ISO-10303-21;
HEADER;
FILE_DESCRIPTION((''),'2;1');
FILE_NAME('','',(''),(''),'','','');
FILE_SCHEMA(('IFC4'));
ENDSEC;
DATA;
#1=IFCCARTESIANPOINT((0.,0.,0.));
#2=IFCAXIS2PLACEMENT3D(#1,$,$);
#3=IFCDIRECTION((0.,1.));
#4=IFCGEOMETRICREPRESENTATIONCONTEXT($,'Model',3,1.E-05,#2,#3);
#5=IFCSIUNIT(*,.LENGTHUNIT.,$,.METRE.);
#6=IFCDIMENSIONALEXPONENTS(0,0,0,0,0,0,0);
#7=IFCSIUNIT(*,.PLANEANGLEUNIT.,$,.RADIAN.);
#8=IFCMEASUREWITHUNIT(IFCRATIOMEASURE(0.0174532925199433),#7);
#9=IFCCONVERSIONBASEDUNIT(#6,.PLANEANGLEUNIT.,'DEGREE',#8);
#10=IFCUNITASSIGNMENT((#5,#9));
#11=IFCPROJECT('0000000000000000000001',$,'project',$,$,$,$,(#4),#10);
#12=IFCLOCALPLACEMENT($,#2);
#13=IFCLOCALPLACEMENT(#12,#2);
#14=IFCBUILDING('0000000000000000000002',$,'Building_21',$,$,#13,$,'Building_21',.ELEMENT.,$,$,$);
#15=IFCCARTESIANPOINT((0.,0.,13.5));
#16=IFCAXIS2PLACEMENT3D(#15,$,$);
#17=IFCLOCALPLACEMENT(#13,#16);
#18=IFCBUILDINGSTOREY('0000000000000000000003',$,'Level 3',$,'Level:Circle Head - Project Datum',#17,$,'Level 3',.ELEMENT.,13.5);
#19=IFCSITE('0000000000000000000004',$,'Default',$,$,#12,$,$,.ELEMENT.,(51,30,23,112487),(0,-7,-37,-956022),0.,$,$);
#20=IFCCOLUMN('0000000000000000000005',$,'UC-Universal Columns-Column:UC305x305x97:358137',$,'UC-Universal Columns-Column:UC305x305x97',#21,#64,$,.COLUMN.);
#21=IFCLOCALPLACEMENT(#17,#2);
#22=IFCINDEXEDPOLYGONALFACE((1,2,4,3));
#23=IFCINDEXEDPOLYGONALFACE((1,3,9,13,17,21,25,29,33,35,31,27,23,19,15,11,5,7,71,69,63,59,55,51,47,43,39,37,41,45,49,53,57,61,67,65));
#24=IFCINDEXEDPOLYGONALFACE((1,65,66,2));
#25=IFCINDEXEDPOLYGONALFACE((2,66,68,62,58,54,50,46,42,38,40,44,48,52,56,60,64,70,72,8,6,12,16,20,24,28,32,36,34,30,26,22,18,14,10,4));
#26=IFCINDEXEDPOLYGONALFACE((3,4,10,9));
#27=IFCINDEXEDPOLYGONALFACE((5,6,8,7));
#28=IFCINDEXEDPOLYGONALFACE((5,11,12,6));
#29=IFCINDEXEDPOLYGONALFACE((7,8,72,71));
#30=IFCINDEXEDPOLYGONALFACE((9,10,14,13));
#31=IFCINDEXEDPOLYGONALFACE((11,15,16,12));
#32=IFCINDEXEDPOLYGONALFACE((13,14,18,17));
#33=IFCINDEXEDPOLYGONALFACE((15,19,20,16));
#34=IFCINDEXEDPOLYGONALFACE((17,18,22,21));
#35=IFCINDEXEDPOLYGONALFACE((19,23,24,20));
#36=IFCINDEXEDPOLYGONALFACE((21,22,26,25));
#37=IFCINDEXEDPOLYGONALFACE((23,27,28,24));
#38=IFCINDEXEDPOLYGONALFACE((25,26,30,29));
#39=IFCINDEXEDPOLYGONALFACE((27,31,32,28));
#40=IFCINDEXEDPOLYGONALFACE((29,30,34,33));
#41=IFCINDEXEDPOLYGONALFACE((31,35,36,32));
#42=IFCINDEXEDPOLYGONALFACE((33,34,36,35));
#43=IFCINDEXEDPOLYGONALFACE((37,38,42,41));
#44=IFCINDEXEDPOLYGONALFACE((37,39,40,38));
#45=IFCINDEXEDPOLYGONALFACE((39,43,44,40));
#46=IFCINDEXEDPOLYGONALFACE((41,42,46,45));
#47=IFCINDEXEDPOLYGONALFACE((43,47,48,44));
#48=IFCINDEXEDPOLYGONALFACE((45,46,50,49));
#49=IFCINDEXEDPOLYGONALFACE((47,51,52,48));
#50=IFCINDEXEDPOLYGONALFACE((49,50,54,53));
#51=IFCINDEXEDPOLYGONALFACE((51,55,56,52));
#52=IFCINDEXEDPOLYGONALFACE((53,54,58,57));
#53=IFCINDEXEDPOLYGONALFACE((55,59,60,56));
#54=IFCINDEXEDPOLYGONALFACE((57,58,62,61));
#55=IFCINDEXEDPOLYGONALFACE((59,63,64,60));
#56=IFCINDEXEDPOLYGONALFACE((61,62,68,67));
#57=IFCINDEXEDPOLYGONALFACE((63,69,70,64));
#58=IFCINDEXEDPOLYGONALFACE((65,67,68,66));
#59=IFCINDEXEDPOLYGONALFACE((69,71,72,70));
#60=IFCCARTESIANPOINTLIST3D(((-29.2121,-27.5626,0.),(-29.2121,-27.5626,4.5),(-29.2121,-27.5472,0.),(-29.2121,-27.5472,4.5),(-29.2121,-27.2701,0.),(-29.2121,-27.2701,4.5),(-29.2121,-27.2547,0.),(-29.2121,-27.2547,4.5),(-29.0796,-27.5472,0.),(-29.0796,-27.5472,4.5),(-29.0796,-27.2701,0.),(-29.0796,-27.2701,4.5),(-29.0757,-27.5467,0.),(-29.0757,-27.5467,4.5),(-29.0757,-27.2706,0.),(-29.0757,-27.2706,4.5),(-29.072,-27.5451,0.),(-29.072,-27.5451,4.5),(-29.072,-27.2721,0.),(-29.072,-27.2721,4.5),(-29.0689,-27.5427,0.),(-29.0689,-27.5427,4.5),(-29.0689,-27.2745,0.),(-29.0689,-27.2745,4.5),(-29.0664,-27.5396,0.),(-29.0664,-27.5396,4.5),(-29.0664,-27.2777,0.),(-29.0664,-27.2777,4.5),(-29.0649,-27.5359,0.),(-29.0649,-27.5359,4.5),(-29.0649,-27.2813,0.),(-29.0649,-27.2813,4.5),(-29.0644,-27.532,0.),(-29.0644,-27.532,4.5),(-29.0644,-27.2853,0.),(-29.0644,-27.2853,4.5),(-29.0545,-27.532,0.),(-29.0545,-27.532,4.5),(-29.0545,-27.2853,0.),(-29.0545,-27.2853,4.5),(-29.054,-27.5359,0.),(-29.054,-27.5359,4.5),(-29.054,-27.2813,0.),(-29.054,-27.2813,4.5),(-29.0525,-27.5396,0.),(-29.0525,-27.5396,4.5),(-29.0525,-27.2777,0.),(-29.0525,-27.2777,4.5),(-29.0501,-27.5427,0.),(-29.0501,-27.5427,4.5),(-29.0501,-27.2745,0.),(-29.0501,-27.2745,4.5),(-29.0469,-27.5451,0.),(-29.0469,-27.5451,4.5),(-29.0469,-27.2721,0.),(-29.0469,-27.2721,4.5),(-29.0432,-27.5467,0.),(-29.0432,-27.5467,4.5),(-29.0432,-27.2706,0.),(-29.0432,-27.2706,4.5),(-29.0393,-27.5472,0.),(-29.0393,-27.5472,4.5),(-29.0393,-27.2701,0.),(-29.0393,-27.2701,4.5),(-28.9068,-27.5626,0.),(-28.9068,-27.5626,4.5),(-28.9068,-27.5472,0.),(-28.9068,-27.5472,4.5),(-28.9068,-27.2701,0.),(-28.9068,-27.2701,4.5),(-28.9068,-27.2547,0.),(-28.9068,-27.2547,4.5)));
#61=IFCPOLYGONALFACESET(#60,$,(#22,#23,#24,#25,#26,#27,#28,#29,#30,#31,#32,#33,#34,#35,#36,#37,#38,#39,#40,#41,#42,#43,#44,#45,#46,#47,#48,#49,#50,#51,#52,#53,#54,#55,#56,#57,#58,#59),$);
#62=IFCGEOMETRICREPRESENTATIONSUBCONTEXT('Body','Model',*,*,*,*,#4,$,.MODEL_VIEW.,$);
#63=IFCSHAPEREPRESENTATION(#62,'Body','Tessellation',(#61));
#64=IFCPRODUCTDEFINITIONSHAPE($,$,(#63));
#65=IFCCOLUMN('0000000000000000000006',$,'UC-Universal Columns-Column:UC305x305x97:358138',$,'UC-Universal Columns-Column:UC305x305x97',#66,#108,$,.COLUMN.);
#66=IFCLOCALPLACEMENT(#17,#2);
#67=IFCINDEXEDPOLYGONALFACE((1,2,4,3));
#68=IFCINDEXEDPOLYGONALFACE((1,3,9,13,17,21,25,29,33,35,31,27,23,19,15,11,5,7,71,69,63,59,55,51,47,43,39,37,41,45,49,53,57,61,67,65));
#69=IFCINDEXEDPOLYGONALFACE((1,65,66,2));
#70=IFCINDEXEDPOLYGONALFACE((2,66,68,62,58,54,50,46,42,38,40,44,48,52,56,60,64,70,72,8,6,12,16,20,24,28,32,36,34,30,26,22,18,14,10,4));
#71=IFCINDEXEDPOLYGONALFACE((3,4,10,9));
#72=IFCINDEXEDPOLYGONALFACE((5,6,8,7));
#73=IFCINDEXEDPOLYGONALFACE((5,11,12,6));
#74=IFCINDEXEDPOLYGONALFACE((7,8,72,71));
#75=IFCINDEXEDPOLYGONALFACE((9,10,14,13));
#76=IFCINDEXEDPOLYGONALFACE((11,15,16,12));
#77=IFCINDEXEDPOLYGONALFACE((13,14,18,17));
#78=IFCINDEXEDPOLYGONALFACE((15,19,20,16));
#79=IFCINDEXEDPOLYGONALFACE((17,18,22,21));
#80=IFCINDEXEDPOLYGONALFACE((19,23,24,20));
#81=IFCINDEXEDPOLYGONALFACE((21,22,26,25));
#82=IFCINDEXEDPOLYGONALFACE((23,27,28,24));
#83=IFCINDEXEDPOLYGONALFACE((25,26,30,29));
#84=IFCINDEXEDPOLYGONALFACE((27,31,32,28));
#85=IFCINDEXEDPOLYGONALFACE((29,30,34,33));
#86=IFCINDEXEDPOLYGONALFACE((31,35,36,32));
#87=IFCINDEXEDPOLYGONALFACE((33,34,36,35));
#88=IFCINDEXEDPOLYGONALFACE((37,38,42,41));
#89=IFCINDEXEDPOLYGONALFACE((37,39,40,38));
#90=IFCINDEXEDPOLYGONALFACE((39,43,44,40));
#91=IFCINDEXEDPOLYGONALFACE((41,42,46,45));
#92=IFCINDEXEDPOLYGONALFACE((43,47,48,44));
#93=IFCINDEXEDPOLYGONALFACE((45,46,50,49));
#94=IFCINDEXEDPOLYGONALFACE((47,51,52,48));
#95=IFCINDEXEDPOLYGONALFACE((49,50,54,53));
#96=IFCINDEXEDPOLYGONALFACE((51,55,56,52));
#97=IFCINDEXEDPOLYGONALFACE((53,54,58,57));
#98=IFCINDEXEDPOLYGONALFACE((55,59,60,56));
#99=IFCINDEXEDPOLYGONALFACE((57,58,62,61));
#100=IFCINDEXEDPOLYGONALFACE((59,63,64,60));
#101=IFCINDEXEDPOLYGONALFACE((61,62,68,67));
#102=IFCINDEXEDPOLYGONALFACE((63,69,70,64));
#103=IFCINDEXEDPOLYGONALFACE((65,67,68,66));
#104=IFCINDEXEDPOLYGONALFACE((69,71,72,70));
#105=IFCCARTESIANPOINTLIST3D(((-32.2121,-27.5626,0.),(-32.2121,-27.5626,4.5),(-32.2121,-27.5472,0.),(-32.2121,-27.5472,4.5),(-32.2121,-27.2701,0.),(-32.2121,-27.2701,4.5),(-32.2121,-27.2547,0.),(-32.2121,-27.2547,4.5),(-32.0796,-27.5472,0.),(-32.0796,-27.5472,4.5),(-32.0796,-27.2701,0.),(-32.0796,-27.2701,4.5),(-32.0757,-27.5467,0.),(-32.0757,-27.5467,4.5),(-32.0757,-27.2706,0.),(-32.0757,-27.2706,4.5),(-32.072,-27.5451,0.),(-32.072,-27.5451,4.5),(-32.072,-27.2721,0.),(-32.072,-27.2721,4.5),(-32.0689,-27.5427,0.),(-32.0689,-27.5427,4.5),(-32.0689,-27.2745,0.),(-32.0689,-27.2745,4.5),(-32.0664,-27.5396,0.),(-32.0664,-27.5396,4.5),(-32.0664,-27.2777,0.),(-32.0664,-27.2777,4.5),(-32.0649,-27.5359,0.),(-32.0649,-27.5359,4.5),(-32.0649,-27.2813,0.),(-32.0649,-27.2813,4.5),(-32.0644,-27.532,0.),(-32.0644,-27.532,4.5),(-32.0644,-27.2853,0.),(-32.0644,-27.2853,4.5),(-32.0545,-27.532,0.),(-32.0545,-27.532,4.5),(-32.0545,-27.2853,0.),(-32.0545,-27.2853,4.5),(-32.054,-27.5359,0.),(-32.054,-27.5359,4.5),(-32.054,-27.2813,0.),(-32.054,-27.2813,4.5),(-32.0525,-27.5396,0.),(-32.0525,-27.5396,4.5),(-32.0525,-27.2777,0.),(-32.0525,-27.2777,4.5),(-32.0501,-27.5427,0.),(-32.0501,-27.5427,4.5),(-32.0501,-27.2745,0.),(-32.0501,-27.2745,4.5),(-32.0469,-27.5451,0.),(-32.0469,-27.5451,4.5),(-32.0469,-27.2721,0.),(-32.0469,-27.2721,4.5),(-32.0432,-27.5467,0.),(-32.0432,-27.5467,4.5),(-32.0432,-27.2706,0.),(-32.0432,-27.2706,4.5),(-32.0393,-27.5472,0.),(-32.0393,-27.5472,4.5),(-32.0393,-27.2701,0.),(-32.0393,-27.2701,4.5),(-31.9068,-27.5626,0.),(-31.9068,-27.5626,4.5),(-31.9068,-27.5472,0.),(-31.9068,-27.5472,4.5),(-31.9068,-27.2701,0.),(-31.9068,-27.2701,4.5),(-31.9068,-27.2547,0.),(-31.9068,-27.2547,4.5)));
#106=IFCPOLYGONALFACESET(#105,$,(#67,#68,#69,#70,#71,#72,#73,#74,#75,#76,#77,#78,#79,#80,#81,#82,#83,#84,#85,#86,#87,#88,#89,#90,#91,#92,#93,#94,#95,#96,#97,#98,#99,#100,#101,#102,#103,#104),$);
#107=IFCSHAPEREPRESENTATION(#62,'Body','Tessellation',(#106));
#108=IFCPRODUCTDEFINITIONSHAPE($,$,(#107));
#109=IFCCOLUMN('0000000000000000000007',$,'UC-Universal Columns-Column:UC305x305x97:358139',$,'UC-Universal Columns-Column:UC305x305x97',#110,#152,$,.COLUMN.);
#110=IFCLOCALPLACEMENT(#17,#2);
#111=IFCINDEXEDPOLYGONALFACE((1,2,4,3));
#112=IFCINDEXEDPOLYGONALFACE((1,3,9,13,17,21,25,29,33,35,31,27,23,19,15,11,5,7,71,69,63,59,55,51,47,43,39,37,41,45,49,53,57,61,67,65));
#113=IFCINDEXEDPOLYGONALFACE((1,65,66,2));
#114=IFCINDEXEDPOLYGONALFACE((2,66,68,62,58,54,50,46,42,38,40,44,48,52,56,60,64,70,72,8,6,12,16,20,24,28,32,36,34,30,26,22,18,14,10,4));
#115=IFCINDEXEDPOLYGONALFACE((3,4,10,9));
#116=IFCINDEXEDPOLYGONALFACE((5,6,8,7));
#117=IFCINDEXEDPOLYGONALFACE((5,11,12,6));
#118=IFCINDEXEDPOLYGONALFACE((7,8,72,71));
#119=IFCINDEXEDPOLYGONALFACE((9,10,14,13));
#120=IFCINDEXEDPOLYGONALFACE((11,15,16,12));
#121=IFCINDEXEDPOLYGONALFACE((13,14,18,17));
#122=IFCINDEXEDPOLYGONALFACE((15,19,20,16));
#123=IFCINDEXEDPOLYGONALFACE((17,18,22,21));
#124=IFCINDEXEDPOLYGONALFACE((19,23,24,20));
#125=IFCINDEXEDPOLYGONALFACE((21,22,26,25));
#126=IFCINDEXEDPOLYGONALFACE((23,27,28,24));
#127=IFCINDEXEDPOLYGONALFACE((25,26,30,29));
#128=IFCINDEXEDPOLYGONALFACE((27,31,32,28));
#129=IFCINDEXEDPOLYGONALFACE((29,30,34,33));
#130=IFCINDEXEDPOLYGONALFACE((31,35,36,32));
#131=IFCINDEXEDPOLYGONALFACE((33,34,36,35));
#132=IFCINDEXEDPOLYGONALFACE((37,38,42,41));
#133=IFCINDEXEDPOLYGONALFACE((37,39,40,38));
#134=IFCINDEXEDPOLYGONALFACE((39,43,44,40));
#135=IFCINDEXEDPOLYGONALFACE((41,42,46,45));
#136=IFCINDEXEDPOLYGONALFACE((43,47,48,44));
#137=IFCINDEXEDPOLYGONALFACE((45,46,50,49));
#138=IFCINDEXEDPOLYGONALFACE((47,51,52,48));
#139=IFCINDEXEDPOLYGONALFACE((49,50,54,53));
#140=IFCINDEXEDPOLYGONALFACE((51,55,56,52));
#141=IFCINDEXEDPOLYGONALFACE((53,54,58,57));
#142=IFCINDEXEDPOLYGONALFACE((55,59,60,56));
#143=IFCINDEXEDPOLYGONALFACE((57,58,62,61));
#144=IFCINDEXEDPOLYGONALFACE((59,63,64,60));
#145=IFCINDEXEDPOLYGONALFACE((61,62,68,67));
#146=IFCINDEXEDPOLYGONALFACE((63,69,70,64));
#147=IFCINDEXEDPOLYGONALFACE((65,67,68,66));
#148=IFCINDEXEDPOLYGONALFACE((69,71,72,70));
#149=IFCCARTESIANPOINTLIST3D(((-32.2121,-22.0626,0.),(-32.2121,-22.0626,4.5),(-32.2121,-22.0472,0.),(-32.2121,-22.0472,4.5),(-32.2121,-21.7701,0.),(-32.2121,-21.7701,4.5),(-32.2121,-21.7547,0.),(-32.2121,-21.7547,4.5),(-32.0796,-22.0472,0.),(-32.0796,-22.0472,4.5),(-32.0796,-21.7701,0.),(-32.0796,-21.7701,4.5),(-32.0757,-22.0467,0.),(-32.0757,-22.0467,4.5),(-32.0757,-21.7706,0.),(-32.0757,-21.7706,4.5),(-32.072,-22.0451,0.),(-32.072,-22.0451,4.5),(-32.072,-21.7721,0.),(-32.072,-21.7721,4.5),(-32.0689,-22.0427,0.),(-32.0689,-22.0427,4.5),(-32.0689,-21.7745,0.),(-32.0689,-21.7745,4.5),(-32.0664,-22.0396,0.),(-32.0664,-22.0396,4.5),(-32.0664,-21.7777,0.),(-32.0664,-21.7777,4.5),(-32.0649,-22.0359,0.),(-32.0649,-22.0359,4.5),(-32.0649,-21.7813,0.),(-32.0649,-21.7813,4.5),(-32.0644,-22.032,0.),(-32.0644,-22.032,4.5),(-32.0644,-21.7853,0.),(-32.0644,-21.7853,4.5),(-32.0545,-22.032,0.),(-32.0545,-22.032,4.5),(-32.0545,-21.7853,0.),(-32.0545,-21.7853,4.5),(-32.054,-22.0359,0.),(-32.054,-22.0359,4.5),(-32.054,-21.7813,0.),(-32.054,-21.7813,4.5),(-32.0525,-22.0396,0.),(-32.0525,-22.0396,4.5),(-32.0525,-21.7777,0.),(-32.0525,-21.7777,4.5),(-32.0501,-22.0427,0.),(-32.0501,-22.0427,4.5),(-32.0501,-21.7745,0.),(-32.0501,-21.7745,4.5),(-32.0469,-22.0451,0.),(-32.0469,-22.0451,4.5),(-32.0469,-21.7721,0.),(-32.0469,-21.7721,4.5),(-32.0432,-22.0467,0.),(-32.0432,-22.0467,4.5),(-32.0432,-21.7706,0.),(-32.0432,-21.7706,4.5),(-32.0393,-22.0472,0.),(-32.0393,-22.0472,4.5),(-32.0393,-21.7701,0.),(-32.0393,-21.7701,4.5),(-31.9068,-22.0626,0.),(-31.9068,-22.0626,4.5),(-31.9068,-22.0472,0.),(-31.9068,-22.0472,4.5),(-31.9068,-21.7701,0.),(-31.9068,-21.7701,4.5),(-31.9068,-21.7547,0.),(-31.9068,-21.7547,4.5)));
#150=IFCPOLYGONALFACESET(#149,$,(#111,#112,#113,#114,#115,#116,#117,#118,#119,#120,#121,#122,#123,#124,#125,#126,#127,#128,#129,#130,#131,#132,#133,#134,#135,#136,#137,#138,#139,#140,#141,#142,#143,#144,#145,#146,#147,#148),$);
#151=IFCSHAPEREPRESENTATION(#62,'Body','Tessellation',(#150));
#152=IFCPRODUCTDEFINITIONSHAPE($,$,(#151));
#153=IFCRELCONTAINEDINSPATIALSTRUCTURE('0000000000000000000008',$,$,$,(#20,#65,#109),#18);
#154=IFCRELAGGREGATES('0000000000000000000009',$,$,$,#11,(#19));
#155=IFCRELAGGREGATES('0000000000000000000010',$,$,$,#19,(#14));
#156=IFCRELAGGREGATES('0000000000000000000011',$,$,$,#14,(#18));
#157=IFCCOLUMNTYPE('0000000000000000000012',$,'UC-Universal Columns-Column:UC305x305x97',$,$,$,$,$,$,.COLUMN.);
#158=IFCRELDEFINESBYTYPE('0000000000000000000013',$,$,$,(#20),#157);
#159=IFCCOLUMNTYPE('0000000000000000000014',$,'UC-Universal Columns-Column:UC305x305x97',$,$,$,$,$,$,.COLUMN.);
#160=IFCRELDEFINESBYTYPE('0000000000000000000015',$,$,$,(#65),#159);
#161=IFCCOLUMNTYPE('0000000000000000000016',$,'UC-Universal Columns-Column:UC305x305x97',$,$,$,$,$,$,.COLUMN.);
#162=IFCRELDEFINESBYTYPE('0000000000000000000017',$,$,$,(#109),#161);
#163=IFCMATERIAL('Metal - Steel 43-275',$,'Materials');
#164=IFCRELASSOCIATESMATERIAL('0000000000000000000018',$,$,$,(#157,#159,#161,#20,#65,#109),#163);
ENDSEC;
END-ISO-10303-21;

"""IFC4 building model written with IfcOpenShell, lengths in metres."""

from ifc_helpers import new_model, entity, si_unit, converted_unit, direction, frame, frame_2d, origin, place, context, subcontext, project, spatial, polyline, circle_curve, parameter, trimmed, segment, composite_curve, i_section, outline, extrude, source, transform, mapped, material, material_profile, profile_set, profile_usage, type_object, type_shapes, element, save


model = new_model("IFC4")

# Units and contexts
model_context = context("Model", 3, precision=1e-05, world=origin(), true_north=direction((0.0, 1.0)))
body_context = subcontext(model_context, "Body", "Model", "MODEL_VIEW")
ifc_project = project(units=[si_unit("LENGTHUNIT", "METRE"), converted_unit("PLANEANGLEUNIT", "DEGREE", entity("IfcRatioMeasure", 0.0174532925199433), si_unit("PLANEANGLEUNIT", "RADIAN"), dimensions=[0, 0, 0, 0, 0, 0, 0])], contexts=[model_context])

# Site, building, storey
site_placement = place(None, origin())
site = spatial("IfcSite", under=ifc_project, at=site_placement, Name="Default", CompositionType="ELEMENT", RefLatitude=(51, 30, 23, 112487), RefLongitude=(0, -7, -37, -956022), RefElevation=0.0)
building_placement = place(site_placement, origin())
building = spatial("IfcBuilding", under=site, at=building_placement, Name="Building_21", LongName="Building_21", CompositionType="ELEMENT")
storey_placement = place(building_placement, frame((0.0, 0.0, 13.5)))
storey = spatial("IfcBuildingStorey", under=building, at=storey_placement, Name="Level 3", ObjectType="Level:Circle Head - Project Datum", LongName="Level 3", CompositionType="ELEMENT", Elevation=13.5)

# Columns
ifc_material_1 = material(Name="Metal - Steel 43-275", Category="Materials")
ifc_material_profile_1 = material_profile(ifc_material_1, outline(composite_curve([segment(polyline([(-0.1527, 0.154, 0.0), (0.1527, 0.154, 0.0)]), True, "CONTINUOUS"), segment(polyline([(0.1527, 0.154, 0.0), (0.1527, 0.1386, 0.0)]), True, "CONTINUOUS"), segment(polyline([(0.1527, 0.1386, 0.0), (0.0201, 0.1386, 0.0)]), True, "CONTINUOUS"), segment(trimmed(circle_curve(frame((0.0201, 0.1234, 0.0)), 0.0152), [parameter(90.0)], [parameter(180.0)], True, "PARAMETER"), True, "CONTINUOUS"), segment(polyline([(0.0049, 0.1234, 0.0), (0.0049, -0.1234, 0.0)]), True, "CONTINUOUS"), segment(trimmed(circle_curve(frame((0.0201, -0.1234, 0.0)), 0.0152), [parameter(180.0)], [parameter(270.0)], True, "PARAMETER"), True, "CONTINUOUS"), segment(polyline([(0.0201, -0.1386, 0.0), (0.1527, -0.1386, 0.0)]), True, "CONTINUOUS"), segment(polyline([(0.1527, -0.1386, 0.0), (0.1527, -0.154, 0.0)]), True, "CONTINUOUS"), segment(polyline([(0.1527, -0.154, 0.0), (-0.1527, -0.154, 0.0)]), True, "CONTINUOUS"), segment(polyline([(-0.1527, -0.154, 0.0), (-0.1527, -0.1386, 0.0)]), True, "CONTINUOUS"), segment(polyline([(-0.1527, -0.1386, 0.0), (-0.0201, -0.1386, 0.0)]), True, "CONTINUOUS"), segment(trimmed(circle_curve(frame((-0.0201, -0.1234, 0.0)), 0.0152), [parameter(270.0)], [parameter(0.0)], True, "PARAMETER"), True, "CONTINUOUS"), segment(polyline([(-0.0049, -0.1234, 0.0), (-0.005, 0.1234, 0.0)]), True, "CONTINUOUS"), segment(trimmed(circle_curve(frame((-0.0201, 0.1234, 0.0)), 0.0152), [parameter(0.0)], [parameter(90.0)], True, "PARAMETER"), True, "CONTINUOUS"), segment(polyline([(-0.0201, 0.1386, 0.0), (-0.1527, 0.1386, 0.0)]), True, "CONTINUOUS"), segment(polyline([(-0.1527, 0.1386, 0.0), (-0.1527, 0.154, 0.0)]), True, "CONTINUOUS")], self_intersect=False), kind="CURVE"), Name="UC305x305x97")
ifc_material_profile_2 = material_profile(ifc_material_1, outline(composite_curve([segment(polyline([(0.1527, 0.154, 0.0), (0.1527, 0.1386, 0.0)]), True, "CONTINUOUS"), segment(polyline([(0.1527, 0.1386, 0.0), (0.0049, 0.1386, 0.0)]), True, "CONTINUOUS"), segment(polyline([(0.0049, 0.1386, 0.0), (0.0049, -0.1386, 0.0)]), True, "CONTINUOUS"), segment(polyline([(0.0049, -0.1386, 0.0), (0.1527, -0.1386, 0.0)]), True, "CONTINUOUS"), segment(polyline([(0.1527, -0.1386, 0.0), (0.1527, -0.154, 0.0)]), True, "CONTINUOUS"), segment(polyline([(0.1527, -0.154, 0.0), (-0.1527, -0.154, 0.0)]), True, "CONTINUOUS"), segment(polyline([(-0.1527, -0.154, 0.0), (-0.1527, -0.1386, 0.0)]), True, "CONTINUOUS"), segment(polyline([(-0.1527, -0.1386, 0.0), (-0.005, -0.1386, 0.0)]), True, "CONTINUOUS"), segment(polyline([(-0.005, -0.1386, 0.0), (-0.005, 0.1386, 0.0)]), True, "CONTINUOUS"), segment(polyline([(-0.005, 0.1386, 0.0), (-0.1527, 0.1386, 0.0)]), True, "CONTINUOUS"), segment(polyline([(-0.1527, 0.1386, 0.0), (-0.1527, 0.154, 0.0)]), True, "CONTINUOUS"), segment(polyline([(-0.1527, 0.154, 0.0), (0.1527, 0.154, 0.0)]), True, "CONTINUOUS")], self_intersect=False), kind="CURVE"), Name="UC305x305x97")
ifc_profile_set = profile_set([ifc_material_profile_1, ifc_material_profile_2], Name="UC305x305x97")
ifc_profile_usage_1 = profile_usage(ifc_profile_set)
column_type_1 = type_object("IfcColumnType", Name="UC-Universal Columns-Column:UC305x305x97", PredefinedType="COLUMN", material=ifc_profile_set)
shared_shape_1 = source(origin(), body_context, "Body", "SweptSolid", [
    extrude(i_section(OverallWidth=0.3053, OverallDepth=0.3079, WebThickness=0.0099, FlangeThickness=0.0154, FilletRadius=0.0152, at=frame_2d((0.0, 0.0), x_axis=(0.0, 1.0))), frame((-29.0595, -27.4086, 13.5), z_axis=(0.0, 0.0, 1.0), x_axis=(0.0, -1.0, 0.0)), (0.0, 0.0, 1.0), 4.5),
])
type_shapes(column_type_1, [shared_shape_1])
column_1_placement = place(storey_placement, frame((0.0, 0.0, -13.5)))
element("IfcColumn", 1, at=column_1_placement, inside=storey, type_object=column_type_1, material=ifc_profile_usage_1, Name="UC-Universal Columns-Column:UC305x305x97:358137", ObjectType="UC-Universal Columns-Column:UC305x305x97", PredefinedType="COLUMN", context=body_context, shape_type="MappedRepresentation", body=[
    mapped(shared_shape_1, transform((0.0, 0.0, 0.0), scale=1.0)),
])
ifc_profile_usage_2 = profile_usage(ifc_profile_set)
column_type_2 = type_object("IfcColumnType", Name="UC-Universal Columns-Column:UC305x305x97", PredefinedType="COLUMN", material=ifc_profile_set)
shared_shape_2 = source(origin(), body_context, "Body", "SweptSolid", [
    extrude(i_section(OverallWidth=0.3053, OverallDepth=0.3079, WebThickness=0.0099, FlangeThickness=0.0154, FilletRadius=0.0152, at=frame_2d((0.0, 0.0), x_axis=(0.0, 1.0))), frame((-32.0595, -27.4086, 13.5), z_axis=(0.0, 0.0, 1.0), x_axis=(0.0, -1.0, 0.0)), (0.0, 0.0, 1.0), 4.5),
])
type_shapes(column_type_2, [shared_shape_2])
column_2_placement = place(storey_placement, frame((0.0, 0.0, -13.5)))
element("IfcColumn", 2, at=column_2_placement, inside=storey, type_object=column_type_2, material=ifc_profile_usage_2, Name="UC-Universal Columns-Column:UC305x305x97:358138", ObjectType="UC-Universal Columns-Column:UC305x305x97", PredefinedType="COLUMN", context=body_context, shape_type="MappedRepresentation", body=[
    mapped(shared_shape_2, transform((0.0, 0.0, 0.0), scale=1.0)),
])
ifc_profile_usage_3 = profile_usage(ifc_profile_set)
column_type_3 = type_object("IfcColumnType", Name="UC-Universal Columns-Column:UC305x305x97", PredefinedType="COLUMN", material=ifc_profile_set)
shared_shape_3 = source(origin(), body_context, "Body", "SweptSolid", [
    extrude(i_section(OverallWidth=0.3053, OverallDepth=0.3079, WebThickness=0.0099, FlangeThickness=0.0154, FilletRadius=0.0152, at=frame_2d((0.0, 0.0), x_axis=(0.0, 1.0))), frame((-32.0595, -21.9086, 13.5), z_axis=(0.0, 0.0, 1.0), x_axis=(0.0, -1.0, 0.0)), (0.0, 0.0, 1.0), 4.5),
])
type_shapes(column_type_3, [shared_shape_3])
column_3_placement = place(storey_placement, frame((0.0, 0.0, -13.5)))
element("IfcColumn", 3, at=column_3_placement, inside=storey, type_object=column_type_3, material=ifc_profile_usage_3, Name="UC-Universal Columns-Column:UC305x305x97:358139", ObjectType="UC-Universal Columns-Column:UC305x305x97", PredefinedType="COLUMN", context=body_context, shape_type="MappedRepresentation", body=[
    mapped(shared_shape_3, transform((0.0, 0.0, 0.0), scale=1.0)),
])

save(model, "model.ifc")
